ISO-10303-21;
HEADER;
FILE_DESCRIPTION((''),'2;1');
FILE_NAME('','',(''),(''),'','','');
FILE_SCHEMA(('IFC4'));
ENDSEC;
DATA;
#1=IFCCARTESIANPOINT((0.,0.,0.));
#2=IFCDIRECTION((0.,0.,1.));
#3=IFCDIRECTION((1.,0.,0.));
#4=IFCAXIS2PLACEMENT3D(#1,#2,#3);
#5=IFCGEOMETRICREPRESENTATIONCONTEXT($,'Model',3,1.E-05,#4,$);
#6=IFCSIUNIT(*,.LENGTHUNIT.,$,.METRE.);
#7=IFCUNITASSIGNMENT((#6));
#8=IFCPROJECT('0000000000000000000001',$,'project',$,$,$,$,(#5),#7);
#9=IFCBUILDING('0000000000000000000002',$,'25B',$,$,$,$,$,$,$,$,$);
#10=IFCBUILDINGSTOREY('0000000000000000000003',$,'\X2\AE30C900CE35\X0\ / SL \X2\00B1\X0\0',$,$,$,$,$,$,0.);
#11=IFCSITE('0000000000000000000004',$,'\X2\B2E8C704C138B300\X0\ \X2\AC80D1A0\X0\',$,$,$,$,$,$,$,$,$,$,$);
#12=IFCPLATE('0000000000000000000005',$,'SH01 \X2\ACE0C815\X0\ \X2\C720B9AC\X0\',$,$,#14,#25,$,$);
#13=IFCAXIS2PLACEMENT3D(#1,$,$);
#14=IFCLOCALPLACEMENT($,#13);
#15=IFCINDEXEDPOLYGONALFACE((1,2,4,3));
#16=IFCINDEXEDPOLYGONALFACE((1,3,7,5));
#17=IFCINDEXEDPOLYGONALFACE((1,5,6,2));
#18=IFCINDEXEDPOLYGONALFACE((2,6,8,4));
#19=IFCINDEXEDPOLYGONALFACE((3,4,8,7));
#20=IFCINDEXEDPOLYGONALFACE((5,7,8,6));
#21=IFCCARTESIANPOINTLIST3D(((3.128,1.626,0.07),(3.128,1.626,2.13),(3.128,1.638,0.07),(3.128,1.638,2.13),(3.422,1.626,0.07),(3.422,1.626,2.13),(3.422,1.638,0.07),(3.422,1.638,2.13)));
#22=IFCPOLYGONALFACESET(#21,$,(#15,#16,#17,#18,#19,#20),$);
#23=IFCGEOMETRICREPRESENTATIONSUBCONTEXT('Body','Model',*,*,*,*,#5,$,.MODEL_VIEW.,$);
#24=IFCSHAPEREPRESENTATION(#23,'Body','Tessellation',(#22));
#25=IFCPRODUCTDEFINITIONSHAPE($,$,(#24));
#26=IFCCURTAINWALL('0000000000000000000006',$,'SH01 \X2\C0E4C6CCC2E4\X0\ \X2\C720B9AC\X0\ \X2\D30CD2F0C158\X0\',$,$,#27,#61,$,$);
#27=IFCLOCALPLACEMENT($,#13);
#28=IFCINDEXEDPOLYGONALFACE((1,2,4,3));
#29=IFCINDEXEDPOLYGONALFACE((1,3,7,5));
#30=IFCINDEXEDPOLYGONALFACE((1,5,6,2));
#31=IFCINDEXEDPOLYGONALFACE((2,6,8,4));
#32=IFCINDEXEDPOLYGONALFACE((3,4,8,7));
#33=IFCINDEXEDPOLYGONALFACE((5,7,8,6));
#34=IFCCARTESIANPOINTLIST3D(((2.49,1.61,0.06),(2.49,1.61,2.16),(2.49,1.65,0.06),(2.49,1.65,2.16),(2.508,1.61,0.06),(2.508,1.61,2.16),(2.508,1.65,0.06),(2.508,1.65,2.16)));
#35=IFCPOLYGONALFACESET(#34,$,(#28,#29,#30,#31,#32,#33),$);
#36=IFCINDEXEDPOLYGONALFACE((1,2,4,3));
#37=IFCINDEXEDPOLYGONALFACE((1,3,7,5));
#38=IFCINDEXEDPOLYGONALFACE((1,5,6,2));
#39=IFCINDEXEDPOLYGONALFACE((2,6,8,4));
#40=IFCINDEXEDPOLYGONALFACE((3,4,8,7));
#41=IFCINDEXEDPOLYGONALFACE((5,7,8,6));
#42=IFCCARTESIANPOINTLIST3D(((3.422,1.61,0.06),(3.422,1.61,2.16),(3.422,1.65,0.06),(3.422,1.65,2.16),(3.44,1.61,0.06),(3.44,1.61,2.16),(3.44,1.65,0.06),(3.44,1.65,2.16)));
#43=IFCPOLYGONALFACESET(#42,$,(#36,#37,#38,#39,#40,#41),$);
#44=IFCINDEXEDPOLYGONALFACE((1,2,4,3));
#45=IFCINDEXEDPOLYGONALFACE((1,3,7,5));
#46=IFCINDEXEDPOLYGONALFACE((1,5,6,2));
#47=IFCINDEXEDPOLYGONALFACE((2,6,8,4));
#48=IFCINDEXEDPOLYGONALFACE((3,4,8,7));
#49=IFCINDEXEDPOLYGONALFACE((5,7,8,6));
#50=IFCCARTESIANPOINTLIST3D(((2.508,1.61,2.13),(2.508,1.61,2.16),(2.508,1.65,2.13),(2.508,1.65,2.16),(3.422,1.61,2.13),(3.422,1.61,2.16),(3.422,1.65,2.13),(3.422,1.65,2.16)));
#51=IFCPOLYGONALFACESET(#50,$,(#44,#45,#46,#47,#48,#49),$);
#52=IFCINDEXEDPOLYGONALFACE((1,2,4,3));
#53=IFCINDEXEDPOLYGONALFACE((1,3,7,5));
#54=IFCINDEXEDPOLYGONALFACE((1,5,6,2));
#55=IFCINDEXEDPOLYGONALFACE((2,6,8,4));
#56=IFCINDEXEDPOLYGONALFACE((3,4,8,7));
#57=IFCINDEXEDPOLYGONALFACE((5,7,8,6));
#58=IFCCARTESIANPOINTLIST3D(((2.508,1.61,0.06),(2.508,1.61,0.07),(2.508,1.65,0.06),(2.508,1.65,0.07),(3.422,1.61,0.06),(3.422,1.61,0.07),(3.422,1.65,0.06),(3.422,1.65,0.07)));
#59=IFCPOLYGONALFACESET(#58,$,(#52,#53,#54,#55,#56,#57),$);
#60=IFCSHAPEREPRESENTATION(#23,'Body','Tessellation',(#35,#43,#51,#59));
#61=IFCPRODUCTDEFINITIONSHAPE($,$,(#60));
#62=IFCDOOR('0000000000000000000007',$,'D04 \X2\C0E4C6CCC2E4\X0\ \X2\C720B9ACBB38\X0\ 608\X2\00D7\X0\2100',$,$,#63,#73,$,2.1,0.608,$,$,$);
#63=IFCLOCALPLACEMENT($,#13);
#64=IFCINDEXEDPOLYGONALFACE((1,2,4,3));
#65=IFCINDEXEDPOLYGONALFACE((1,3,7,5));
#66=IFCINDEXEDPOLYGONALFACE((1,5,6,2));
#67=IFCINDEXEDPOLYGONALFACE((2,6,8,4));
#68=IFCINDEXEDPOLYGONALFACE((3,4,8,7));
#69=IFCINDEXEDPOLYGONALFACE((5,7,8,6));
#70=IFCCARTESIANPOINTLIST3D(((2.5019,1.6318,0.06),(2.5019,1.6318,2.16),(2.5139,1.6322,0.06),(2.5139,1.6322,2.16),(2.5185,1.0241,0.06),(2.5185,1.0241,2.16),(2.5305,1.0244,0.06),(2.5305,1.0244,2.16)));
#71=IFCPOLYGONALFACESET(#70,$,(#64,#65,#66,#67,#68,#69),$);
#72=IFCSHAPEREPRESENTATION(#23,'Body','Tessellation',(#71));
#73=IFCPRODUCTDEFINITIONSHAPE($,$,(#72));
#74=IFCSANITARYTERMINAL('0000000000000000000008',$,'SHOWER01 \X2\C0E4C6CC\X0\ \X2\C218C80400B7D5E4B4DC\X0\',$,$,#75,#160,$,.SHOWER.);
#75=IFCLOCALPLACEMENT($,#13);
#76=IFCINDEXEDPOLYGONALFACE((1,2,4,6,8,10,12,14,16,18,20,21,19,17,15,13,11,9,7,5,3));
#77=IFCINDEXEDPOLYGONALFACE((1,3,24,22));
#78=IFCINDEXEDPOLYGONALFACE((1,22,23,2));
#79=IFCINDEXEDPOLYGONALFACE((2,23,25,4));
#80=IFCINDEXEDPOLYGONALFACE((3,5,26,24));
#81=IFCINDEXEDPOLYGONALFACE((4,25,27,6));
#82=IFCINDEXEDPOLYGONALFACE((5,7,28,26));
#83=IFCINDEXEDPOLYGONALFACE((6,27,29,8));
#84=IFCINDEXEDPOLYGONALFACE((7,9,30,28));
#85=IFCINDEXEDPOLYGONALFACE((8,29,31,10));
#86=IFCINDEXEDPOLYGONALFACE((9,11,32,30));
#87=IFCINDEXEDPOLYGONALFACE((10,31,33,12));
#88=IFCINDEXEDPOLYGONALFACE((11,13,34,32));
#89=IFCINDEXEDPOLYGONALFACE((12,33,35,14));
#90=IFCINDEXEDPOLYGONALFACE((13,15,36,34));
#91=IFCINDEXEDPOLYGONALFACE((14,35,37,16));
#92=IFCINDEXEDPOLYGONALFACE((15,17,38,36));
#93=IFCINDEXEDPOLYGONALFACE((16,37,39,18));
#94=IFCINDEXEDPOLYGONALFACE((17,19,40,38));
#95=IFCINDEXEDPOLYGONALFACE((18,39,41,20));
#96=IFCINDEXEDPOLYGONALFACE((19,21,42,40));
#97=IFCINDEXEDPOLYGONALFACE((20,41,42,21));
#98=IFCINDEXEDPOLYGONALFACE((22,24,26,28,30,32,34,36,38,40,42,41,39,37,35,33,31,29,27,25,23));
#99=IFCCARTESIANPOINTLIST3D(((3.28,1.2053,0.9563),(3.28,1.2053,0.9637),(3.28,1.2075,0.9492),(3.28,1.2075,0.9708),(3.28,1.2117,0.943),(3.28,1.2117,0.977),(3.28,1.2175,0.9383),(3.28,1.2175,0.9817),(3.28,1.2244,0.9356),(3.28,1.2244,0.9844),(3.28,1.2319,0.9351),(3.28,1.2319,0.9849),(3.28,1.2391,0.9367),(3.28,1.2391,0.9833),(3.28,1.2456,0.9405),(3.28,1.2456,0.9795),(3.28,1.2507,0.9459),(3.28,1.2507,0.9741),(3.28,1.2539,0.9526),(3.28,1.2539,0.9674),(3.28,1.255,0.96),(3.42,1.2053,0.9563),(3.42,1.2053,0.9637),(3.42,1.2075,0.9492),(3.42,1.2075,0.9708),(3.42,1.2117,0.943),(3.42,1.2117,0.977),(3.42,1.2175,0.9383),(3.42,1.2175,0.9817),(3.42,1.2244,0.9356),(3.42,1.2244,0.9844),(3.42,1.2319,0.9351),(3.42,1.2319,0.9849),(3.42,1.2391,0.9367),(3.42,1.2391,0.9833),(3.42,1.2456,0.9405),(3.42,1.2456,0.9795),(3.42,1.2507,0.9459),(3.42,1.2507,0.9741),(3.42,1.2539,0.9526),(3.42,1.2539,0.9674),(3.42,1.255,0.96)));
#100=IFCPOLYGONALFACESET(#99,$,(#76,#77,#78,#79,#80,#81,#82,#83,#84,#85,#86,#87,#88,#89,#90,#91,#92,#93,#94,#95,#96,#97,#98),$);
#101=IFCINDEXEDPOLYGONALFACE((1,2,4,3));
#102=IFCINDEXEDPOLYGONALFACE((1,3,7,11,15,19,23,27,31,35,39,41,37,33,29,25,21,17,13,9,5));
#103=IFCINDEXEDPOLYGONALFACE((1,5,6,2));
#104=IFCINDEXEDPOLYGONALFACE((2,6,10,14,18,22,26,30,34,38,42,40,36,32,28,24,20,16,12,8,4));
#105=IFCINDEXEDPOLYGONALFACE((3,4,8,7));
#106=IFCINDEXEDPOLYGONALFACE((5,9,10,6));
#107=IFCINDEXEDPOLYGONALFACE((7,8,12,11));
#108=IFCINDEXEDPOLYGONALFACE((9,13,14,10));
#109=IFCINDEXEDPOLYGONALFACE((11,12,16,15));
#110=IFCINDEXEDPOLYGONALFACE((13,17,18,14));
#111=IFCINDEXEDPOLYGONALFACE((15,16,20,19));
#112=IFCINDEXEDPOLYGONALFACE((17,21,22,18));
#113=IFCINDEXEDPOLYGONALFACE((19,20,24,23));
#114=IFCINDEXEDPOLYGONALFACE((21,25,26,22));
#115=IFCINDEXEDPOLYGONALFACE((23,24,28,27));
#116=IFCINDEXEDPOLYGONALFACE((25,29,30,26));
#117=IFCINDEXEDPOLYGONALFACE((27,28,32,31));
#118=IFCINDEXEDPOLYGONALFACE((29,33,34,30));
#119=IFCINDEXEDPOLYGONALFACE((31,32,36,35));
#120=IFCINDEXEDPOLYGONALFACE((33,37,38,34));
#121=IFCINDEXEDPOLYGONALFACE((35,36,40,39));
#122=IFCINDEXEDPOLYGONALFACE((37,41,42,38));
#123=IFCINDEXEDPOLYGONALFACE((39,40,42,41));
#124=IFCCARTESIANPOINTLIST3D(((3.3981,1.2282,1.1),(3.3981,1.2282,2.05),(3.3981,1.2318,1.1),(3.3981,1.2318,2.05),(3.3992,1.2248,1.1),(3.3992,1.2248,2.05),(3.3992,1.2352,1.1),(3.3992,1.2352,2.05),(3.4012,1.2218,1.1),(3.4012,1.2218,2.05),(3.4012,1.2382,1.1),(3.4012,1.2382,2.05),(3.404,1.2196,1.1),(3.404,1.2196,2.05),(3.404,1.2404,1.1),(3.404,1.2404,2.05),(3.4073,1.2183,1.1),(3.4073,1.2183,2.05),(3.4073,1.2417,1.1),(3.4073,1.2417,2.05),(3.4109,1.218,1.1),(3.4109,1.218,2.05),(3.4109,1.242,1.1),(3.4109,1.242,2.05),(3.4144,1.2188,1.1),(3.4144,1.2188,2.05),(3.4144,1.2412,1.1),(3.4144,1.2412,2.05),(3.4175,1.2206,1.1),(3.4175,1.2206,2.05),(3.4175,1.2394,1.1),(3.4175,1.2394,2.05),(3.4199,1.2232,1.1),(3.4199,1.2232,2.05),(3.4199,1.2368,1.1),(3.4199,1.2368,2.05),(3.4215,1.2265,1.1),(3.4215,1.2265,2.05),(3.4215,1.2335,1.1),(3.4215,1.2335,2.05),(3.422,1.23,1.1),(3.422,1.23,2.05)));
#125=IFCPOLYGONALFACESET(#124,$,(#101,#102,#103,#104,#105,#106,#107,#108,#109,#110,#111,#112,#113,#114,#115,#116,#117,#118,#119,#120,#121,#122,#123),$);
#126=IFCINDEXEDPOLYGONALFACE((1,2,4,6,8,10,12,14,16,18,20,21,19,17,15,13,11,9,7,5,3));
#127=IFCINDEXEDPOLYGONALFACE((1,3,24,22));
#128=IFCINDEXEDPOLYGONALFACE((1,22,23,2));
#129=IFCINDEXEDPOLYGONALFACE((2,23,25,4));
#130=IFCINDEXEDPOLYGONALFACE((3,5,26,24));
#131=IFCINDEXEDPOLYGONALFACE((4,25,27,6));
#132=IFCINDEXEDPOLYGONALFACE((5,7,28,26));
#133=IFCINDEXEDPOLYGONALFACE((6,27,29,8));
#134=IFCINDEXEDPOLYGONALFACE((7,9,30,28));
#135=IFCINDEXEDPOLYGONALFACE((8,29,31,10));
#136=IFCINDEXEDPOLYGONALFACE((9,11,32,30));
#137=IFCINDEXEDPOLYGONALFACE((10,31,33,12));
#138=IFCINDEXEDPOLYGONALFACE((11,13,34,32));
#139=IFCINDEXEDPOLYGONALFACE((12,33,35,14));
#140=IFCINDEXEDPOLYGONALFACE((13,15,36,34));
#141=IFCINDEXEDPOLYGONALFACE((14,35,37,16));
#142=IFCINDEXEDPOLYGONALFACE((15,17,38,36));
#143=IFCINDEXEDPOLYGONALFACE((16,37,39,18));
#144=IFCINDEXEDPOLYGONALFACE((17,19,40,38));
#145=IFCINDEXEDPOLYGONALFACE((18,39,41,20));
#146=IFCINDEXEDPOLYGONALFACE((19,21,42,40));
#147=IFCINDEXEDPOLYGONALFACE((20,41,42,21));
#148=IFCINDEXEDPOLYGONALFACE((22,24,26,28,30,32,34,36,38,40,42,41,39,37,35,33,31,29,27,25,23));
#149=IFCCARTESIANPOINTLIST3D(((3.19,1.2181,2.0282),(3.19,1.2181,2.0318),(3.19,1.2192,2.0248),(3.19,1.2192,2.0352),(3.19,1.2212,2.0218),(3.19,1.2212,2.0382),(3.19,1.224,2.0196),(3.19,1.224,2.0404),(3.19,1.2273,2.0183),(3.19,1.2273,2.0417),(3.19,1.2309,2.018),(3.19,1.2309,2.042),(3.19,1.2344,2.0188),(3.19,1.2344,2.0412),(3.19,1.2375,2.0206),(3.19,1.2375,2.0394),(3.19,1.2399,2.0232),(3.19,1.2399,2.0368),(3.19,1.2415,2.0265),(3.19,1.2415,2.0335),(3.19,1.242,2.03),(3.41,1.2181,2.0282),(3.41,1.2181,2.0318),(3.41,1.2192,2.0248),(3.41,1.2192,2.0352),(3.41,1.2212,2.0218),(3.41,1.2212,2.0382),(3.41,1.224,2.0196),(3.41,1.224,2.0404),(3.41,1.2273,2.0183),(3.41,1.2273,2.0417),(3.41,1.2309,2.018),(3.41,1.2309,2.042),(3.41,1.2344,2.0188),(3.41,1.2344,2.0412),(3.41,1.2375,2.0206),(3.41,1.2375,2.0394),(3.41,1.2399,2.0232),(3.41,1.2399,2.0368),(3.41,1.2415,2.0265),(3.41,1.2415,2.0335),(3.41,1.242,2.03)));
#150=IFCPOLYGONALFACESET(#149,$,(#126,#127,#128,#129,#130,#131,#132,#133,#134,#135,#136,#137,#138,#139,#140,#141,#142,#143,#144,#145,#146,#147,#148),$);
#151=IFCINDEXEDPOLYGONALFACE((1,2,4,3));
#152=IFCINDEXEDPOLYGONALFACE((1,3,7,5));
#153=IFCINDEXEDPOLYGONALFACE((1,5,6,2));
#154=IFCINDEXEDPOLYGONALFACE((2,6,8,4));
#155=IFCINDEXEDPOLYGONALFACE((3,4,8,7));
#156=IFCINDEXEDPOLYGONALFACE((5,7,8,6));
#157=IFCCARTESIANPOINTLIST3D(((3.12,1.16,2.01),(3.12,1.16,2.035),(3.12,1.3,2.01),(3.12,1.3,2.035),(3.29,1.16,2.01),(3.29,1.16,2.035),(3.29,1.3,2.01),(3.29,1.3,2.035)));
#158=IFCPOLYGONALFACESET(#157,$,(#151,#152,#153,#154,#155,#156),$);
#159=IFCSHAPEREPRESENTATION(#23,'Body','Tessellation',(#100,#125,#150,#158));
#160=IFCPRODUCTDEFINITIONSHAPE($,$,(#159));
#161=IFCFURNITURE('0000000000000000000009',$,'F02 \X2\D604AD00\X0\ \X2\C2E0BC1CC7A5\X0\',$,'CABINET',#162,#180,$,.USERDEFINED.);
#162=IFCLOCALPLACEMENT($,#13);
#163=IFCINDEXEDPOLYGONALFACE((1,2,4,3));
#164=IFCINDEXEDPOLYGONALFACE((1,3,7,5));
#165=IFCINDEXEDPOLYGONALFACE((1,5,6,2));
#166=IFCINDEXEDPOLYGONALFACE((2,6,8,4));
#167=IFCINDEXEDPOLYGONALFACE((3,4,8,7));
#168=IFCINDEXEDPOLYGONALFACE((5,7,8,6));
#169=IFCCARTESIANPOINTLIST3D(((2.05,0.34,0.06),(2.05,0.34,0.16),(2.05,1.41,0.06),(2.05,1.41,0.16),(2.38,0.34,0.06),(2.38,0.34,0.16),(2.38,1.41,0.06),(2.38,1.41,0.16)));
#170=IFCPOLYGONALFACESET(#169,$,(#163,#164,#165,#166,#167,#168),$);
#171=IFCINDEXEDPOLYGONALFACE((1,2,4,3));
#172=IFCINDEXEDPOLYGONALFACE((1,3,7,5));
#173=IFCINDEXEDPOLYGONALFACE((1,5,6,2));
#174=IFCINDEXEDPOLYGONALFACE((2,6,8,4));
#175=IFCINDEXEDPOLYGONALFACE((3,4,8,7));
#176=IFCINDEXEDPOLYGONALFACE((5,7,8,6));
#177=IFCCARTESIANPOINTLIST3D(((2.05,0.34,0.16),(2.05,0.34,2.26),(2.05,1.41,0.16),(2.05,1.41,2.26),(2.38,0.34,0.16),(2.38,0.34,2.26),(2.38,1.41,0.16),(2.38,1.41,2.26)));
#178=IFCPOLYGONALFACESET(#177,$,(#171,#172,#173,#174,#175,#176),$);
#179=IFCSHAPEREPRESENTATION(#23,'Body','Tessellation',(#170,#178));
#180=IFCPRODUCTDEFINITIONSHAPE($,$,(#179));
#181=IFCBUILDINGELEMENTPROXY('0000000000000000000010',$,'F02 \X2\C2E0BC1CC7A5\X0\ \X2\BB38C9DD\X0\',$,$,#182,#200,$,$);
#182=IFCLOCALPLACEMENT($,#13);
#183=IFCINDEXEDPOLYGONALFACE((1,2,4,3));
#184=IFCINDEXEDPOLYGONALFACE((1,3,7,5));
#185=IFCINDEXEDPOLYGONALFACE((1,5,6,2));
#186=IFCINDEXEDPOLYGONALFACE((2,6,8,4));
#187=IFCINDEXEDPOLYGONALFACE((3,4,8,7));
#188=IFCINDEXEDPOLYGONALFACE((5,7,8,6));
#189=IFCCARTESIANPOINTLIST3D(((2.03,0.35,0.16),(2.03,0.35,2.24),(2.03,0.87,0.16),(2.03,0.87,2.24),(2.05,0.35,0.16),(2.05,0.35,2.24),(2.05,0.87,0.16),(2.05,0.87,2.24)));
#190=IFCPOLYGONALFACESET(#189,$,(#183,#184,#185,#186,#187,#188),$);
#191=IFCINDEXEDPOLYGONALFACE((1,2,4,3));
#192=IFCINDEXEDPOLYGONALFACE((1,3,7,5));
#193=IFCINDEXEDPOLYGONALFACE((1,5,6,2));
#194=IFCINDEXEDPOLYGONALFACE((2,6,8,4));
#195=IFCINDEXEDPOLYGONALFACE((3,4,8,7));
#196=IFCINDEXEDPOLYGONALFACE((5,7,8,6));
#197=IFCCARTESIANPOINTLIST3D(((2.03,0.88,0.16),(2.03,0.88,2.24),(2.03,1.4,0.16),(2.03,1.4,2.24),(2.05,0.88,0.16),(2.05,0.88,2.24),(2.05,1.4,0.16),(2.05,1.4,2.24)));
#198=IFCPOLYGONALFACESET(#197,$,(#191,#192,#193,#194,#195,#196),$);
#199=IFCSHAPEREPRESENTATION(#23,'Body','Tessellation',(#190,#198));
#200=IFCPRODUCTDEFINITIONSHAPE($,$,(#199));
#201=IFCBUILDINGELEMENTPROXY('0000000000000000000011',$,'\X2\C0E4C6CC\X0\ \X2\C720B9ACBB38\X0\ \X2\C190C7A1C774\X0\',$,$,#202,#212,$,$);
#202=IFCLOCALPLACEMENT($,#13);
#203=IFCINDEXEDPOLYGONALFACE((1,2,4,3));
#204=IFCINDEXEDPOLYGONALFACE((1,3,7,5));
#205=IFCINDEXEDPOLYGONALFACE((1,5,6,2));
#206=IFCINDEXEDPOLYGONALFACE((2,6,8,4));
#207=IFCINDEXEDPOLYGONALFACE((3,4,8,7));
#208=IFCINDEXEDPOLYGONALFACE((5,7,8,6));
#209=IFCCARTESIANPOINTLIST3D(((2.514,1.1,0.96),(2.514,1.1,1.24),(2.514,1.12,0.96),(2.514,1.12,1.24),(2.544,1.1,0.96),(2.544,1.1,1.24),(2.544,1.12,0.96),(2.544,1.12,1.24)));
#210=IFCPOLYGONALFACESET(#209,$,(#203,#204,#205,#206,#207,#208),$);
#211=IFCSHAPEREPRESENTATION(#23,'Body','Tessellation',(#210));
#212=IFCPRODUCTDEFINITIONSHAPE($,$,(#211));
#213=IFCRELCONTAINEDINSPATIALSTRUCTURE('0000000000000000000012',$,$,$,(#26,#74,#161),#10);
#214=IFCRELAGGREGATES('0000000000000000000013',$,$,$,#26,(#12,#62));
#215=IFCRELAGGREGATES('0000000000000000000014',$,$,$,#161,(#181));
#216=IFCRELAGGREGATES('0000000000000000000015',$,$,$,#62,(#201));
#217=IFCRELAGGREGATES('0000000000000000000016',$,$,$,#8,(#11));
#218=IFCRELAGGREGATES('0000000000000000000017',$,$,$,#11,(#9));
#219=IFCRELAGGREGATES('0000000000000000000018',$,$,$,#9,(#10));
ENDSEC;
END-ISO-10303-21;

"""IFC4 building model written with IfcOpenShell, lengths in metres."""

from ifc_helpers import new_model, si_unit, frame, origin_with_axes, place, context, subcontext, project, spatial, polyline, circle, outline, extrude, element, aggregate, save


model = new_model("IFC4")

# Units and contexts
model_context = context("Model", 3, precision=1e-05, world=origin_with_axes())
body_context = subcontext(model_context, "Body", "Model", "MODEL_VIEW")
ifc_project = project(units=[si_unit("LENGTHUNIT", "METRE")], contexts=[model_context])

# Plate
curtain_wall_placement = place(None, origin_with_axes())
plate_placement = place(curtain_wall_placement, origin_with_axes())
plate = element("IfcPlate", 1, at=plate_placement, Name="SH01 고정 유리", context=body_context, shape_type="SweptSolid", body=[
    extrude(outline(polyline([(3.422, 1.626), (3.422, 1.638), (3.128, 1.638), (3.128, 1.626), (3.422, 1.626)])), frame((0.0, 0.0, 0.07)), (0.0, 0.0, 1.0), 2.06),
])

# Site, building, storey
site = spatial("IfcSite", under=ifc_project, Name="단위세대 검토")
building = spatial("IfcBuilding", under=site, Name="25B")
storey = spatial("IfcBuildingStorey", under=building, Name="기준층 / SL ±0", Elevation=0.0)

# Curtain wall, door
curtain_wall = element("IfcCurtainWall", 2, at=curtain_wall_placement, inside=storey, Name="SH01 샤워실 유리 파티션", context=body_context, shape_type="SweptSolid", body=[
    extrude(outline(polyline([(2.508, 1.61), (2.508, 1.65), (2.49, 1.65), (2.49, 1.61), (2.508, 1.61)])), frame((0.0, 0.0, 0.06)), (0.0, 0.0, 1.0), 2.1),
    extrude(outline(polyline([(3.44, 1.61), (3.44, 1.65), (3.422, 1.65), (3.422, 1.61), (3.44, 1.61)])), frame((0.0, 0.0, 0.06)), (0.0, 0.0, 1.0), 2.1),
    extrude(outline(polyline([(3.422, 1.61), (3.422, 1.65), (2.508, 1.65), (2.508, 1.61), (3.422, 1.61)])), frame((0.0, 0.0, 2.13)), (0.0, 0.0, 1.0), 0.03),
    extrude(outline(polyline([(3.422, 1.61), (3.422, 1.65), (2.508, 1.65), (2.508, 1.61), (3.422, 1.61)])), frame((0.0, 0.0, 0.06)), (0.0, 0.0, 1.0), 0.01),
])
door_placement = place(curtain_wall_placement, origin_with_axes())
door = element("IfcDoor", 3, at=door_placement, Name="D04 샤워실 유리문 608×2100", OverallHeight=2.1, OverallWidth=0.608, context=body_context, shape_type="SweptSolid", body=[
    extrude(outline(polyline([(2.5139, 1.6322), (2.5305, 1.0244), (2.5185, 1.0241), (2.5019, 1.6318), (2.5139, 1.6322)])), frame((0.0, 0.0, 0.06)), (0.0, 0.0, 1.0), 2.1),
])
aggregate(curtain_wall, [plate, door])

# Sanitary terminal
sanitary_terminal_1_placement = place(None, origin_with_axes())
element("IfcSanitaryTerminal", 4, at=sanitary_terminal_1_placement, inside=storey, Name="SHOWER01 샤워 수전·헤드", PredefinedType="SHOWER", context=body_context, shape_type="SweptSolid", body=[
    extrude(circle(Radius=0.025), frame((3.42, 1.23, 0.96), z_axis=(-1.0, 0.0, 0.0), x_axis=(0.0, 1.0, 0.0)), (0.0, 0.0, 1.0), 0.14),
    extrude(circle(Radius=0.012), frame((3.41, 1.23, 1.1), z_axis=(0.0, 0.0, 1.0), x_axis=(1.0, 0.0, 0.0)), (0.0, 0.0, 1.0), 0.95),
    extrude(circle(Radius=0.012), frame((3.41, 1.23, 2.03), z_axis=(-1.0, 0.0, 0.0), x_axis=(0.0, 1.0, 0.0)), (0.0, 0.0, 1.0), 0.22),
    extrude(outline(polyline([(3.29, 1.16), (3.29, 1.3), (3.12, 1.3), (3.12, 1.16), (3.29, 1.16)])), frame((0.0, 0.0, 2.01)), (0.0, 0.0, 1.0), 0.025),
])

# Furniture
furniture_1_placement = place(None, origin_with_axes())
furniture_1 = element("IfcFurniture", 5, at=furniture_1_placement, inside=storey, Name="F02 현관 신발장", ObjectType="CABINET", PredefinedType="USERDEFINED", context=body_context, shape_type="SweptSolid", body=[
    extrude(outline(polyline([(2.38, 0.34), (2.38, 1.41), (2.05, 1.41), (2.05, 0.34), (2.38, 0.34)])), frame((0.0, 0.0, 0.06)), (0.0, 0.0, 1.0), 0.1),
    extrude(outline(polyline([(2.38, 0.34), (2.38, 1.41), (2.05, 1.41), (2.05, 0.34), (2.38, 0.34)])), frame((0.0, 0.0, 0.16)), (0.0, 0.0, 1.0), 2.1),
])

# Building element proxies
proxy_1_placement = place(furniture_1_placement, origin_with_axes())
proxy_1 = element("IfcBuildingElementProxy", 6, at=proxy_1_placement, Name="F02 신발장 문짝", context=body_context, shape_type="SweptSolid", body=[
    extrude(outline(polyline([(2.05, 0.35), (2.05, 0.87), (2.03, 0.87), (2.03, 0.35), (2.05, 0.35)])), frame((0.0, 0.0, 0.16)), (0.0, 0.0, 1.0), 2.08),
    extrude(outline(polyline([(2.05, 0.88), (2.05, 1.4), (2.03, 1.4), (2.03, 0.88), (2.05, 0.88)])), frame((0.0, 0.0, 0.16)), (0.0, 0.0, 1.0), 2.08),
])
aggregate(furniture_1, [proxy_1])
proxy_2_placement = place(door_placement, origin_with_axes())
proxy_2 = element("IfcBuildingElementProxy", 7, at=proxy_2_placement, Name="샤워 유리문 손잡이", context=body_context, shape_type="SweptSolid", body=[
    extrude(outline(polyline([(2.544, 1.1), (2.544, 1.12), (2.514, 1.12), (2.514, 1.1), (2.544, 1.1)])), frame((0.0, 0.0, 0.96)), (0.0, 0.0, 1.0), 0.28),
])
aggregate(door, [proxy_2])

save(model, "model.ifc")
